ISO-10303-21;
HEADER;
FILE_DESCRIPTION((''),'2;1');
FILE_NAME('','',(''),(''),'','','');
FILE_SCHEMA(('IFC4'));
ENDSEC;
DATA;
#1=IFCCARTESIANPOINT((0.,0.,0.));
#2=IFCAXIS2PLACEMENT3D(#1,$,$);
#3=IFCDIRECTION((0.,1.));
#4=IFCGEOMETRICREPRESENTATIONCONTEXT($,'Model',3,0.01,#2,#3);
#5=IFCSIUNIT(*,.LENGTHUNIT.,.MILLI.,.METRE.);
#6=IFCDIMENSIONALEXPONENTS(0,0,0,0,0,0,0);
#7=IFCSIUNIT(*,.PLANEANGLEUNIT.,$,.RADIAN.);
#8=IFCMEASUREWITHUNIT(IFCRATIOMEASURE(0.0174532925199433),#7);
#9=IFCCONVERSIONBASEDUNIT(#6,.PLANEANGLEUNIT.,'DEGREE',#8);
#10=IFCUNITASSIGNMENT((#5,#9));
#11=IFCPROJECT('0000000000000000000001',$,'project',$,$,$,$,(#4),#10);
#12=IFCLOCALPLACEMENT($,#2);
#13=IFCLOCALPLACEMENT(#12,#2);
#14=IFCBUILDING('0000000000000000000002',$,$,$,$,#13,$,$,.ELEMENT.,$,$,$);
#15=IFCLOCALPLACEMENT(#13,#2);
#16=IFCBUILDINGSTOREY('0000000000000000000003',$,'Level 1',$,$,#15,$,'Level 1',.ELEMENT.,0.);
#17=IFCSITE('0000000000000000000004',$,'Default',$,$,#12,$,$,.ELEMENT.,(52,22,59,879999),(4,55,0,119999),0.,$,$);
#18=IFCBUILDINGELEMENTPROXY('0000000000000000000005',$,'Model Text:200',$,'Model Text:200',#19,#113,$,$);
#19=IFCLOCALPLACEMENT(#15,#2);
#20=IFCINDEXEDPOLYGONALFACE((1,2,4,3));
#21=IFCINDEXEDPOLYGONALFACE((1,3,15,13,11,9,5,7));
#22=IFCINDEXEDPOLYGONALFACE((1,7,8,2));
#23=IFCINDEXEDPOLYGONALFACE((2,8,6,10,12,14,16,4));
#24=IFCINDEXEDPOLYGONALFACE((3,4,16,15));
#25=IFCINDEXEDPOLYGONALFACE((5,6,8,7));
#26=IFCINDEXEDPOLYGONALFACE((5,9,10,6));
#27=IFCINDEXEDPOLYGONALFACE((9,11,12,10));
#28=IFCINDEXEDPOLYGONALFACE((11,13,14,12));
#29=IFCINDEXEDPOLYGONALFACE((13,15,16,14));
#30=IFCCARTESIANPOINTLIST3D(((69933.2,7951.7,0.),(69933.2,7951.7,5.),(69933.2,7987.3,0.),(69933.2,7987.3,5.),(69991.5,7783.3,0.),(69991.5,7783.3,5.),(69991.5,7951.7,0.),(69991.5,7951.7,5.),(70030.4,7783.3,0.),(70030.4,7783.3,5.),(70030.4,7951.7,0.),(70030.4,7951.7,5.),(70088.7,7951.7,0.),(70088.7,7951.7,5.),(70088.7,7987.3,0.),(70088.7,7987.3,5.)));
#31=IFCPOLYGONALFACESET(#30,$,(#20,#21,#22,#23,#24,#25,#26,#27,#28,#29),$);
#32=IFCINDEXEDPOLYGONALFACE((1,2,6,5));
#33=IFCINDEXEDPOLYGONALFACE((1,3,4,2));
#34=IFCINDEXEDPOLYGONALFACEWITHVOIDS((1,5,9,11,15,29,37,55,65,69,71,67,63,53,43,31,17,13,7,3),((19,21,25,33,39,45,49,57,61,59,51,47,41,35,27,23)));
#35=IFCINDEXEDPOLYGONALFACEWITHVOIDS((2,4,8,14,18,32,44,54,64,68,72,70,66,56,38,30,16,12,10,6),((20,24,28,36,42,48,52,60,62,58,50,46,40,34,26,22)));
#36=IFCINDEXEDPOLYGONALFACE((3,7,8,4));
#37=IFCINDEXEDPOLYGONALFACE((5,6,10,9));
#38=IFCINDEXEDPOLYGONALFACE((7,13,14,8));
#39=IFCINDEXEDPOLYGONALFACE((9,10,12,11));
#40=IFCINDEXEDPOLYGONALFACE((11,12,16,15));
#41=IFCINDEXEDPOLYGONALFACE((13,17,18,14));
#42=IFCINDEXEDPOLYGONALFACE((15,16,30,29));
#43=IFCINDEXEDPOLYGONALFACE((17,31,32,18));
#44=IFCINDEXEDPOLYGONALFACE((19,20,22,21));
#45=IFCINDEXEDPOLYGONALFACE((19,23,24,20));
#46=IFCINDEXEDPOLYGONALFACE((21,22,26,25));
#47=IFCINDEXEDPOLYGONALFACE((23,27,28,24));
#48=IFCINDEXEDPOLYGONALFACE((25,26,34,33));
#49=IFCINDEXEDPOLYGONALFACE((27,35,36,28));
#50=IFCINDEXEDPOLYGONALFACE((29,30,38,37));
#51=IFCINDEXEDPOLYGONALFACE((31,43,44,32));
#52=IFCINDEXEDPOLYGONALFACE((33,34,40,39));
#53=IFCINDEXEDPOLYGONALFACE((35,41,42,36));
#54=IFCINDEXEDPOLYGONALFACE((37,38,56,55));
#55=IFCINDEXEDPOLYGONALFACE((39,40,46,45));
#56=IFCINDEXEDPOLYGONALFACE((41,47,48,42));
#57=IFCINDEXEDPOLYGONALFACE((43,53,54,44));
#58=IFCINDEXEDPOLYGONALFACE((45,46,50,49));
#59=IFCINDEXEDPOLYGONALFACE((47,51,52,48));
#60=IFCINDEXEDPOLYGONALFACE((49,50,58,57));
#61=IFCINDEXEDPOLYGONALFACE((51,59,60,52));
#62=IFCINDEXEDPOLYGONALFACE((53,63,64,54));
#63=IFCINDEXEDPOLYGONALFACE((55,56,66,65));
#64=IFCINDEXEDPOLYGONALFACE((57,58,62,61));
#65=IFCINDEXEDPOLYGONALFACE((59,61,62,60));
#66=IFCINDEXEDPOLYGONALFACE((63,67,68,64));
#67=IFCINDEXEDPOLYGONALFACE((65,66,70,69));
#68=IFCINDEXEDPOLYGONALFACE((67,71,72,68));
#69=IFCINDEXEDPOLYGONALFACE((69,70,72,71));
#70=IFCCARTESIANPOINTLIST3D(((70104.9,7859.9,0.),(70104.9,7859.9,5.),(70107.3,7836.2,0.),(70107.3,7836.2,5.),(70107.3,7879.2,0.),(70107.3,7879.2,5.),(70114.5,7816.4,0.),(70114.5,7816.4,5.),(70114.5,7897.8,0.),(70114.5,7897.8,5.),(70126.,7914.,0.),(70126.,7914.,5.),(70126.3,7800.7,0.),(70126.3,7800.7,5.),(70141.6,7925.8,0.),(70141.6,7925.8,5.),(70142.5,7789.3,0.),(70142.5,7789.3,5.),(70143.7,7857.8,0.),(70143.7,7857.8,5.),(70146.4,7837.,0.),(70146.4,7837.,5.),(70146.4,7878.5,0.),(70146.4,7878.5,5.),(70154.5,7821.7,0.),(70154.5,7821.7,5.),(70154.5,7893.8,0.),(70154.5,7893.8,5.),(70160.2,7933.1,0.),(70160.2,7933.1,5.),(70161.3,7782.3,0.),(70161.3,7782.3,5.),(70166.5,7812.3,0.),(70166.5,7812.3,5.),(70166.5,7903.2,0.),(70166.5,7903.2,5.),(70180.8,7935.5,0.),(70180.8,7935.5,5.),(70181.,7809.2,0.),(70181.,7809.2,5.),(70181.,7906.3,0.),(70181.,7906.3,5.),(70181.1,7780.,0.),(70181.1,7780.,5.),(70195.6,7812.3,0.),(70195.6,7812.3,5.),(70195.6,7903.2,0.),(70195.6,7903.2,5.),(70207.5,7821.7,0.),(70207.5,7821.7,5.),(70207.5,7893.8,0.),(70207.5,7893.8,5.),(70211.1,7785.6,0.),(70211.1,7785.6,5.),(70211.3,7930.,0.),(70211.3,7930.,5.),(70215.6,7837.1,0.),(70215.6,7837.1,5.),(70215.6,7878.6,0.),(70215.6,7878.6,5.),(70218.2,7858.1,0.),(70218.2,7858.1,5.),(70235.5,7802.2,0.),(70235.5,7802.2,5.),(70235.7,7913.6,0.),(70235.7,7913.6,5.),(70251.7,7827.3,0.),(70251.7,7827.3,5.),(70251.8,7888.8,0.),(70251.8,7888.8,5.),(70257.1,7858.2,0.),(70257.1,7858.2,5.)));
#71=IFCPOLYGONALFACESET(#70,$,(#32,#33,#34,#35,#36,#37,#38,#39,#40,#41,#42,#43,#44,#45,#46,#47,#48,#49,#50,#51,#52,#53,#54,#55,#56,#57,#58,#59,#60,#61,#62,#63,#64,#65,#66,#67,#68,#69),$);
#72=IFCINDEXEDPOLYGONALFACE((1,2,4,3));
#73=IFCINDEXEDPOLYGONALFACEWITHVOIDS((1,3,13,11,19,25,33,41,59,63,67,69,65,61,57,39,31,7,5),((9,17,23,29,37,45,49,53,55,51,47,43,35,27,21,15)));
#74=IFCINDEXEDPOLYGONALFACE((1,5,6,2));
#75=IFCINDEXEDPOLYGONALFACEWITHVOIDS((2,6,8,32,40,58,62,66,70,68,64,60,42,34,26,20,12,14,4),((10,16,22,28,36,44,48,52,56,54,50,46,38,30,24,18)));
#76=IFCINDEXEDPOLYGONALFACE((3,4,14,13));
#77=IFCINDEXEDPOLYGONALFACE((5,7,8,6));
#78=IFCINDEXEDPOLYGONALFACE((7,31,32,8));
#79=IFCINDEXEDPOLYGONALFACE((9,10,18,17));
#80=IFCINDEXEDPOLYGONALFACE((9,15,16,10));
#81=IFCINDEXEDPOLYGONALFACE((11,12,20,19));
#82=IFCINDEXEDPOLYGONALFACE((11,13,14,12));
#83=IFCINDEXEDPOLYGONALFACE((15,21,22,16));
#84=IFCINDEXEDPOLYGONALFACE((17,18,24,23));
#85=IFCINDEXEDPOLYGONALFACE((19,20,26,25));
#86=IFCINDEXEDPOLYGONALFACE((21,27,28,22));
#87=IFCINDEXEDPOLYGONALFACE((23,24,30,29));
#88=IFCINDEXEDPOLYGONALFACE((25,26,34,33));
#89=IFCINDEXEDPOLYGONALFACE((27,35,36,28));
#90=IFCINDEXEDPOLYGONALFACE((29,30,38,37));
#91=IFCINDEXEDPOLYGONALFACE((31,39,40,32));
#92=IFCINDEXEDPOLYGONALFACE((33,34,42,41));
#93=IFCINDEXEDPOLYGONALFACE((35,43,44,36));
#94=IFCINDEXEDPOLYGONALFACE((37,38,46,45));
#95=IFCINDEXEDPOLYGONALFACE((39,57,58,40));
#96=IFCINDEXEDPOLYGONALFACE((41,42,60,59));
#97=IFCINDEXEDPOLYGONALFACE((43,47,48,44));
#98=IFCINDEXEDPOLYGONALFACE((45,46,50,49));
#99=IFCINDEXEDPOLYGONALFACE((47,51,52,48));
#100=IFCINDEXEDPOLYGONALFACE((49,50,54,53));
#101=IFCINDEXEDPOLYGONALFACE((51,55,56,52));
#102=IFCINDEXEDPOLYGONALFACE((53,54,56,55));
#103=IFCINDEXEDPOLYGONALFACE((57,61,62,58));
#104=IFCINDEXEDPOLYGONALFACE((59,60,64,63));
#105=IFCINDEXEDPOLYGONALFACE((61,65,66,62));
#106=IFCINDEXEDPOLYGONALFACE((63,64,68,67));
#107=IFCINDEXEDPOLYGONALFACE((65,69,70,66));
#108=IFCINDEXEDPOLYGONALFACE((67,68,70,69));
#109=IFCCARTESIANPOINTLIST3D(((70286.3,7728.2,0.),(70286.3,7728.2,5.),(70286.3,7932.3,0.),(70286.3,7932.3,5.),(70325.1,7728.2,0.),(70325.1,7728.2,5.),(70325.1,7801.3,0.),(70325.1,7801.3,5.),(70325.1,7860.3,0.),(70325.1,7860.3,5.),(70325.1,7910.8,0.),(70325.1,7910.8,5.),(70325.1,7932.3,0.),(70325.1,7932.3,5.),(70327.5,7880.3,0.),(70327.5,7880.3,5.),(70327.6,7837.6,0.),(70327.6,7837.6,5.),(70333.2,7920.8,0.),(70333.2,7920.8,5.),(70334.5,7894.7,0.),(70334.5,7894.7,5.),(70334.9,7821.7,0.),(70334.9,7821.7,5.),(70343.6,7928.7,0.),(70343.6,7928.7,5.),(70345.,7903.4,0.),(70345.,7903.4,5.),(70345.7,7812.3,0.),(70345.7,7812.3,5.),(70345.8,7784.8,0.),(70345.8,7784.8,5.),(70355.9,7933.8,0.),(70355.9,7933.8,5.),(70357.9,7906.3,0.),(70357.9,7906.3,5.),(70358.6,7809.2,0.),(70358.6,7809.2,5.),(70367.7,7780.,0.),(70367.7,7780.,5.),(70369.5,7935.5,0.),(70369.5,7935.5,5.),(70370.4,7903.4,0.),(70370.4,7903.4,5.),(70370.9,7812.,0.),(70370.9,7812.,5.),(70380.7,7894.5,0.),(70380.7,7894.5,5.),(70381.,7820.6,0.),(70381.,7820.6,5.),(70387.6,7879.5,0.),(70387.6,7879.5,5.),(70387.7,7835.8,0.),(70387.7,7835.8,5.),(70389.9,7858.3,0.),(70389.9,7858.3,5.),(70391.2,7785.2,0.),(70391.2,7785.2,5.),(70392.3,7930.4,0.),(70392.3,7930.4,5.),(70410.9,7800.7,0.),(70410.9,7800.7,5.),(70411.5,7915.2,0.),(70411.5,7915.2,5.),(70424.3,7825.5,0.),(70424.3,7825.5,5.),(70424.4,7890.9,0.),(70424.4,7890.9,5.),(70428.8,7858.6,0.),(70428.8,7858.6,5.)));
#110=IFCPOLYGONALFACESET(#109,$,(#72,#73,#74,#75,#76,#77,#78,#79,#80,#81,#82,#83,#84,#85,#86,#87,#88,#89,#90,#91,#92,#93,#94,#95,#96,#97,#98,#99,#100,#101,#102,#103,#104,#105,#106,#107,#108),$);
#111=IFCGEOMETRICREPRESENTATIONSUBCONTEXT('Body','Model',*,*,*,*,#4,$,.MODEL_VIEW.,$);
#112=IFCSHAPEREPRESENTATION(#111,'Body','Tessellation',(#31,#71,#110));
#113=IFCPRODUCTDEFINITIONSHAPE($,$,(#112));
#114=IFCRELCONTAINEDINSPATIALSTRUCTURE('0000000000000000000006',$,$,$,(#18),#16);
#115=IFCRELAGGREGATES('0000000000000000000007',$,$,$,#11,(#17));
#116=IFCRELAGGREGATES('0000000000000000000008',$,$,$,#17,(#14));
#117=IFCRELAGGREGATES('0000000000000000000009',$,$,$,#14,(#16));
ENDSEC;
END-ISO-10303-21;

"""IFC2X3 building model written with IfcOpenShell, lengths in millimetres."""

from ifc_helpers import new_model, entity, si_unit, converted_unit, direction, frame, origin, place, context, subcontext, project, spatial, polyline, outline, extrude, element, save


model = new_model("IFC2X3")

# Units and contexts
model_context = context("Model", 3, precision=0.01, world=origin(), true_north=direction((0.0, 1.0)))
body_context = subcontext(model_context, "Body", "Model", "MODEL_VIEW")
ifc_project = project(units=[si_unit("LENGTHUNIT", "METRE", prefix="MILLI"), converted_unit("PLANEANGLEUNIT", "DEGREE", entity("IfcRatioMeasure", 0.0174532925199433), si_unit("PLANEANGLEUNIT", "RADIAN"), dimensions=[0, 0, 0, 0, 0, 0, 0])], contexts=[model_context])

# Site, building, storey
site_placement = place(None, origin())
site = spatial("IfcSite", under=ifc_project, at=site_placement, Name="Default", CompositionType="ELEMENT", RefLatitude=(52, 22, 59, 879999), RefLongitude=(4, 55, 0, 119999), RefElevation=0.0)
building_placement = place(site_placement, origin())
building = spatial("IfcBuilding", under=site, at=building_placement, CompositionType="ELEMENT")
storey_placement = place(building_placement, origin())
storey = spatial("IfcBuildingStorey", under=building, at=storey_placement, Name="Level 1", LongName="Level 1", CompositionType="ELEMENT", Elevation=0.0)

# Building element proxy
proxy_1_placement = place(building_placement, origin())
element("IfcBuildingElementProxy", 1, at=proxy_1_placement, inside=storey, Name="Model Text:200", ObjectType="Model Text:200", context=body_context, shape_type="SweptSolid", body=[
    extrude(outline(polyline([(-19.4, -135.2), (19.4, -135.2), (19.4, 33.2), (77.7, 33.2), (77.7, 68.8), (-77.7, 68.8), (-77.7, 33.2), (-19.4, 33.2), (-19.4, -135.2)])), frame((70010.9, 7918.5, 0.0)), (0.0, 0.0, 1.0), 5.0),
    extrude(outline(polyline([(-8.8, -65.7), (15.1, -65.7), (35.5, -60.5), (52.3, -50.4), (65.3, -35.4), (74.1, -17.3), (78.4, 2.1), (75.9, 32.5), (61.8, 58.5), (38.4, 77.1), (8.3, 85.6), (-22.7, 83.3), (-49.0, 69.9), (-67.8, 47.3), (-76.3, 17.5), (-76.0, -3.3), (-70.7, -22.5), (-60.5, -39.2), (-45.5, -52.3), (-27.7, -61.4), (-8.8, -65.7)]), holes=[polyline([(-2.7, -27.2), (-23.1, -22.5), (-37.5, -12.9), (-45.7, 0.0), (-47.3, 14.8), (-42.7, 28.9), (-32.2, 39.9), (-16.3, 46.3), (4.5, 46.9), (25.1, 42.1), (39.6, 32.6), (47.7, 19.7), (49.4, 5.0), (44.8, -9.2), (34.2, -20.2), (18.2, -26.7), (-2.7, -27.2)])]), frame((70171.1, 7857.8, 0.0), z_axis=(0.0, 0.0, 1.0), x_axis=(0.100608, -0.994926, 0.0)), (0.0, 0.0, 1.0), 5.0),
    extrude(outline(polyline([(-73.1, -75.4), (130.9, -75.4), (130.9, -36.6), (57.8, -36.6), (74.3, -15.9), (79.1, 6.0), (73.9, 29.5), (58.4, 49.2), (33.6, 62.6), (0.5, 67.1), (-31.8, 62.8), (-56.1, 49.8), (-71.3, 30.7), (-76.4, 7.8), (-74.7, -5.8), (-69.6, -18.1), (-61.7, -28.5), (-51.7, -36.6), (-73.1, -36.6), (-73.1, -75.4)]), holes=[polyline([(-1.2, -36.6), (-21.2, -34.2), (-35.6, -27.2), (-44.3, -16.7), (-47.2, -3.8), (-44.3, 8.7), (-35.4, 19.0), (-20.4, 25.9), (0.8, 28.2), (23.3, 26.0), (38.5, 19.3), (47.1, 9.2), (49.9, -3.1), (46.8, -16.0), (37.4, -26.8), (21.5, -34.1), (-1.2, -36.6)])]), frame((70361.7, 7859.1, 0.0), z_axis=(0.0, 0.0, 1.0), x_axis=(0.0, -1.0, 0.0)), (0.0, 0.0, 1.0), 5.0),
])

save(model, "model.ifc")
